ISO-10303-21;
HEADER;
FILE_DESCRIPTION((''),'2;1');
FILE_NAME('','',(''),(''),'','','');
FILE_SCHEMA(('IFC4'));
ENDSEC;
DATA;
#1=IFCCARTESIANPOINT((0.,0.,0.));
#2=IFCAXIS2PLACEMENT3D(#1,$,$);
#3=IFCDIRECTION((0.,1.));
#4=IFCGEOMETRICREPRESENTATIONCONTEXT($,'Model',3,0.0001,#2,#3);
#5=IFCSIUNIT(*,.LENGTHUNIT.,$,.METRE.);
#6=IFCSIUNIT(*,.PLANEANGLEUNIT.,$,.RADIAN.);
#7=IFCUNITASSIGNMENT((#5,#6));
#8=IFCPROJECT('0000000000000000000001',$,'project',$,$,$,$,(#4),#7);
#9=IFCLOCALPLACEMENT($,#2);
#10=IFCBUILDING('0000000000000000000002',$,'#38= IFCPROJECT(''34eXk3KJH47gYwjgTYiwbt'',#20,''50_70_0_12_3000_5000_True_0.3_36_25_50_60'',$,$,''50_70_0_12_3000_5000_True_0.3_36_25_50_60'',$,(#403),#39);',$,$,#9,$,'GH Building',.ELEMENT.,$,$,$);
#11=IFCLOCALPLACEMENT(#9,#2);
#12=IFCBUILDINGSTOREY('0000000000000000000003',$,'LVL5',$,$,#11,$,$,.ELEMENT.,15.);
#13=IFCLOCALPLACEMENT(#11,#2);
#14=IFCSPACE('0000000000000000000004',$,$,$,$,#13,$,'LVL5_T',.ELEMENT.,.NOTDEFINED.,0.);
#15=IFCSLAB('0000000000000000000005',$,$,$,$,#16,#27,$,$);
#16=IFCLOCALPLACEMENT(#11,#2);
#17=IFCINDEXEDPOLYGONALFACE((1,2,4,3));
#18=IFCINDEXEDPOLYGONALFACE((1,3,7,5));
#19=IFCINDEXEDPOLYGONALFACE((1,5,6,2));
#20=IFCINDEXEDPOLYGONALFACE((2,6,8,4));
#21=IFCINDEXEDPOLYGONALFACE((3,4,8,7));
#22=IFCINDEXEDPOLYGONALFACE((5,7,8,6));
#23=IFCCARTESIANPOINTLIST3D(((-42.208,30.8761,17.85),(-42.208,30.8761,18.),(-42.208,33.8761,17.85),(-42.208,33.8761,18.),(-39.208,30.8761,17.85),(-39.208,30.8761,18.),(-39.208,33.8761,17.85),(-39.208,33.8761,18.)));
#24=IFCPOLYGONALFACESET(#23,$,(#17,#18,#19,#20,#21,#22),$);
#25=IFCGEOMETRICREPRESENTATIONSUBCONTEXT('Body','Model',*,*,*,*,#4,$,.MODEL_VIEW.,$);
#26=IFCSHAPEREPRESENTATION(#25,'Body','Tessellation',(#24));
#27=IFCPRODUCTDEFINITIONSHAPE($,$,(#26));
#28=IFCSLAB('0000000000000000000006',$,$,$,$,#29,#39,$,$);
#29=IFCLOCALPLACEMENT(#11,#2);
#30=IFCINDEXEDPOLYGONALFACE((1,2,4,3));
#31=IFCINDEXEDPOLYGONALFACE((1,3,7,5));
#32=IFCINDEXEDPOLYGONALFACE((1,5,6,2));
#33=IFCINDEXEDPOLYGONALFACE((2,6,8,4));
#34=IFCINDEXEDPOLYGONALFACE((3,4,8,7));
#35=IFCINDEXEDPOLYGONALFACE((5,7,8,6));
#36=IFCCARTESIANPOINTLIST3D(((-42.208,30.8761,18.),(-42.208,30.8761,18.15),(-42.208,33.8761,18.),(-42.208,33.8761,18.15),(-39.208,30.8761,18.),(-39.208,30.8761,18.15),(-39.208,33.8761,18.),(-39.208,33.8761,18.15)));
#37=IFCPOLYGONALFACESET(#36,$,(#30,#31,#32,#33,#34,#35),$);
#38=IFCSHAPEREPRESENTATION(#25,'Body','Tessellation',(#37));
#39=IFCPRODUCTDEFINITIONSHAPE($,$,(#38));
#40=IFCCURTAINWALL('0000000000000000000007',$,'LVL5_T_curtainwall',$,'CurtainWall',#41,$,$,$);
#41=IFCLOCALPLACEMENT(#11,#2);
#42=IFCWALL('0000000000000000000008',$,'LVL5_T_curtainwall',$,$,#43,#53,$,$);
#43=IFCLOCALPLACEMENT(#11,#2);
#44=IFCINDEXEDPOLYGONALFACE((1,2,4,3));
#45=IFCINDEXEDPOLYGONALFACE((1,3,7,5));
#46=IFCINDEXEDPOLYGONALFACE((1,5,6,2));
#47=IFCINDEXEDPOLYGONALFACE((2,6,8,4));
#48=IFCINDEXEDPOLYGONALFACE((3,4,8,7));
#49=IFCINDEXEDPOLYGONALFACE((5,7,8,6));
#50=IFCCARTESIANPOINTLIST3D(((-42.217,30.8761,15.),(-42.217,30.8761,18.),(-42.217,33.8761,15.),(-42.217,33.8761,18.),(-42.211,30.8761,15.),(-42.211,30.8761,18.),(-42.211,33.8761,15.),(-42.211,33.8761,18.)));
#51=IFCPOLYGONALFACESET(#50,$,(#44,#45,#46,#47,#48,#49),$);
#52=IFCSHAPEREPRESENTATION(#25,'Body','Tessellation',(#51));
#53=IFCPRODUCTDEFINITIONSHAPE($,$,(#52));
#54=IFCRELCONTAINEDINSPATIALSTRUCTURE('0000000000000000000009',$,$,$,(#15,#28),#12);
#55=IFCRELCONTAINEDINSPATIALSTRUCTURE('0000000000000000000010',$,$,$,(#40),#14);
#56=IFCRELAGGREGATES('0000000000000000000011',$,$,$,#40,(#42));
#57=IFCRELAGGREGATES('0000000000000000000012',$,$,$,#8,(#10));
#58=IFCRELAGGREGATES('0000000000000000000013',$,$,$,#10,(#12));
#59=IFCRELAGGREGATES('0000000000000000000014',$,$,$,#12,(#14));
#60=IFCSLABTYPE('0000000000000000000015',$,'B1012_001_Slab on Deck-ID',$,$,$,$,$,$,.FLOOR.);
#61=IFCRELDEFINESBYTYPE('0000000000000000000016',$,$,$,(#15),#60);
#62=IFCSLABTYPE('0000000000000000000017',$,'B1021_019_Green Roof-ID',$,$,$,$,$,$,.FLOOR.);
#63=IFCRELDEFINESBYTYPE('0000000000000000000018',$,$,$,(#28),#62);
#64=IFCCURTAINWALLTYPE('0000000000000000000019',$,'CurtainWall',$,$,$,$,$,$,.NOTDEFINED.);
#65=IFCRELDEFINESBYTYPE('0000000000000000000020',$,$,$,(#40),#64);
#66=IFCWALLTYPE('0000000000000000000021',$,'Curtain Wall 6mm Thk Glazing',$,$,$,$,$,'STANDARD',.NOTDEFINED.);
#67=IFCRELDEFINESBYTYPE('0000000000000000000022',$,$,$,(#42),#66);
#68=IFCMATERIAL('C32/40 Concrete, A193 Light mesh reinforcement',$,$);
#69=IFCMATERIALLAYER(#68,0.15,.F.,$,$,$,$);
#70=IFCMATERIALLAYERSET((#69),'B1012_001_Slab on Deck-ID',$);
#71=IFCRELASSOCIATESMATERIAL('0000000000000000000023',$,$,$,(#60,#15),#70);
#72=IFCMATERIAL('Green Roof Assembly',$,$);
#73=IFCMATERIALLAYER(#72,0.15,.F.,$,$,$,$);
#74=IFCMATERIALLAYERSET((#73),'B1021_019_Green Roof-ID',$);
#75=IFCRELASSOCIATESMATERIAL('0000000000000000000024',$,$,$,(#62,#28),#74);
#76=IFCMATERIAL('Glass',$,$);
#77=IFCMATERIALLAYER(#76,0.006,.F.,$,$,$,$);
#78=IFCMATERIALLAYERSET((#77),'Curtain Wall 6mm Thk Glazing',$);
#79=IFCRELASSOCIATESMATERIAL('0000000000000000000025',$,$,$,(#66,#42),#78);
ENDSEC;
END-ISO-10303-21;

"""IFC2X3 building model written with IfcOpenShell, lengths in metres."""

from ifc_helpers import new_model, si_unit, direction, frame, frame_2d, origin, place, context, subcontext, project, spatial, polyline, rectangle, outline, extrude, material, layer, layer_set, layer_usage, type_object, element, aggregate, save


model = new_model("IFC2X3")

# Units and contexts
model_context = context("Model", 3, precision=0.0001, world=origin(), true_north=direction((0.0, 1.0)))
body_context = subcontext(model_context, "Body", "Model", "MODEL_VIEW")
ifc_project = project(units=[si_unit("LENGTHUNIT", "METRE"), si_unit("PLANEANGLEUNIT", "RADIAN")], contexts=[model_context])

# Building, storey, space
building_placement = place(None, origin())
building = spatial("IfcBuilding", under=ifc_project, at=building_placement, Name="#38= IFCPROJECT('34eXk3KJH47gYwjgTYiwbt',#20,'50_70_0_12_3000_5000_True_0.3_36_25_50_60',$,$,'50_70_0_12_3000_5000_True_0.3_36_25_50_60',$,(#403),#39);", LongName="GH Building", CompositionType="ELEMENT")
storey_placement = place(building_placement, origin())
storey = spatial("IfcBuildingStorey", under=building, at=storey_placement, Name="LVL5", CompositionType="ELEMENT", Elevation=15.0)
space_1_placement = place(storey_placement, origin())
space_1 = spatial("IfcSpace", under=storey, at=space_1_placement, LongName="LVL5_T", CompositionType="ELEMENT", InteriorOrExteriorSpace="NOTDEFINED", ElevationWithFlooring=0.0)

# Slabs
ifc_material_1 = material(Name="C32/40 Concrete, A193 Light mesh reinforcement")
ifc_layer_1 = layer(ifc_material_1, 0.15, ventilated=False)
ifc_layer_set_1 = layer_set([ifc_layer_1], Name="B1012_001_Slab on Deck-ID")
ifc_layer_usage_1 = layer_usage(ifc_layer_set_1, "AXIS3", "NEGATIVE", -0.15)
slab_type_1 = type_object("IfcSlabType", Name="B1012_001_Slab on Deck-ID", PredefinedType="FLOOR", material=ifc_layer_set_1)
slab_1_placement = place(storey_placement, frame((-40.708, 32.3761, 17.85)))
element("IfcSlab", 1, at=slab_1_placement, inside=storey, type_object=slab_type_1, material=ifc_layer_usage_1, context=body_context, shape_type="SweptSolid", body=[
    extrude(outline(polyline([(-1.5, -1.5), (-1.5, 1.5), (1.5, 1.5), (1.5, -1.5), (-1.5, -1.5)])), origin(), (0.0, 0.0, 1.0), 0.15),
])
ifc_material_2 = material(Name="Green Roof Assembly")
ifc_layer_2 = layer(ifc_material_2, 0.15, ventilated=False)
ifc_layer_set_2 = layer_set([ifc_layer_2], Name="B1021_019_Green Roof-ID")
ifc_layer_usage_2 = layer_usage(ifc_layer_set_2, "AXIS3", "NEGATIVE", -0.15)
slab_type_2 = type_object("IfcSlabType", Name="B1021_019_Green Roof-ID", PredefinedType="FLOOR", material=ifc_layer_set_2)
slab_2_placement = place(storey_placement, frame((-40.708, 32.3761, 18.0)))
element("IfcSlab", 2, at=slab_2_placement, inside=storey, type_object=slab_type_2, material=ifc_layer_usage_2, context=body_context, shape_type="SweptSolid", body=[
    extrude(outline(polyline([(-1.5, -1.5), (-1.5, 1.5), (1.5, 1.5), (1.5, -1.5), (-1.5, -1.5)])), origin(), (0.0, 0.0, 1.0), 0.15),
])

# Curtain wall, wall
curtain_wall_type = type_object("IfcCurtainWallType", Name="CurtainWall", PredefinedType="NOTDEFINED")
curtain_wall_placement = place(None, origin())
curtain_wall = element("IfcCurtainWall", 3, at=curtain_wall_placement, inside=space_1, type_object=curtain_wall_type, Name="LVL5_T_curtainwall", ObjectType="CurtainWall")
ifc_material_3 = material(Name="Glass")
ifc_layer_3 = layer(ifc_material_3, 0.006, ventilated=False)
ifc_layer_set_3 = layer_set([ifc_layer_3], Name="Curtain Wall 6mm Thk Glazing")
ifc_layer_usage_3 = layer_usage(ifc_layer_set_3, "AXIS2", "NEGATIVE", -0.003)
wall_type = type_object("IfcWallType", Name="Curtain Wall 6mm Thk Glazing", ElementType="STANDARD", PredefinedType="NOTDEFINED", material=ifc_layer_set_3)
wall_1_placement = place(curtain_wall_placement, frame((-42.208, 33.8761, 15.0), z_axis=(0.0, 0.0, 1.0), x_axis=(0.0, -1.0, 0.0)))
wall_1 = element("IfcWall", 4, at=wall_1_placement, type_object=wall_type, material=ifc_layer_usage_3, Name="LVL5_T_curtainwall", context=body_context, shape_type="SweptSolid", body=[
    extrude(rectangle(XDim=3.0, YDim=0.006, at=frame_2d((1.5, -0.006))), origin(), (0.0, 0.0, 1.0), 3.0),
])
aggregate(curtain_wall, [wall_1])

save(model, "model.ifc")
